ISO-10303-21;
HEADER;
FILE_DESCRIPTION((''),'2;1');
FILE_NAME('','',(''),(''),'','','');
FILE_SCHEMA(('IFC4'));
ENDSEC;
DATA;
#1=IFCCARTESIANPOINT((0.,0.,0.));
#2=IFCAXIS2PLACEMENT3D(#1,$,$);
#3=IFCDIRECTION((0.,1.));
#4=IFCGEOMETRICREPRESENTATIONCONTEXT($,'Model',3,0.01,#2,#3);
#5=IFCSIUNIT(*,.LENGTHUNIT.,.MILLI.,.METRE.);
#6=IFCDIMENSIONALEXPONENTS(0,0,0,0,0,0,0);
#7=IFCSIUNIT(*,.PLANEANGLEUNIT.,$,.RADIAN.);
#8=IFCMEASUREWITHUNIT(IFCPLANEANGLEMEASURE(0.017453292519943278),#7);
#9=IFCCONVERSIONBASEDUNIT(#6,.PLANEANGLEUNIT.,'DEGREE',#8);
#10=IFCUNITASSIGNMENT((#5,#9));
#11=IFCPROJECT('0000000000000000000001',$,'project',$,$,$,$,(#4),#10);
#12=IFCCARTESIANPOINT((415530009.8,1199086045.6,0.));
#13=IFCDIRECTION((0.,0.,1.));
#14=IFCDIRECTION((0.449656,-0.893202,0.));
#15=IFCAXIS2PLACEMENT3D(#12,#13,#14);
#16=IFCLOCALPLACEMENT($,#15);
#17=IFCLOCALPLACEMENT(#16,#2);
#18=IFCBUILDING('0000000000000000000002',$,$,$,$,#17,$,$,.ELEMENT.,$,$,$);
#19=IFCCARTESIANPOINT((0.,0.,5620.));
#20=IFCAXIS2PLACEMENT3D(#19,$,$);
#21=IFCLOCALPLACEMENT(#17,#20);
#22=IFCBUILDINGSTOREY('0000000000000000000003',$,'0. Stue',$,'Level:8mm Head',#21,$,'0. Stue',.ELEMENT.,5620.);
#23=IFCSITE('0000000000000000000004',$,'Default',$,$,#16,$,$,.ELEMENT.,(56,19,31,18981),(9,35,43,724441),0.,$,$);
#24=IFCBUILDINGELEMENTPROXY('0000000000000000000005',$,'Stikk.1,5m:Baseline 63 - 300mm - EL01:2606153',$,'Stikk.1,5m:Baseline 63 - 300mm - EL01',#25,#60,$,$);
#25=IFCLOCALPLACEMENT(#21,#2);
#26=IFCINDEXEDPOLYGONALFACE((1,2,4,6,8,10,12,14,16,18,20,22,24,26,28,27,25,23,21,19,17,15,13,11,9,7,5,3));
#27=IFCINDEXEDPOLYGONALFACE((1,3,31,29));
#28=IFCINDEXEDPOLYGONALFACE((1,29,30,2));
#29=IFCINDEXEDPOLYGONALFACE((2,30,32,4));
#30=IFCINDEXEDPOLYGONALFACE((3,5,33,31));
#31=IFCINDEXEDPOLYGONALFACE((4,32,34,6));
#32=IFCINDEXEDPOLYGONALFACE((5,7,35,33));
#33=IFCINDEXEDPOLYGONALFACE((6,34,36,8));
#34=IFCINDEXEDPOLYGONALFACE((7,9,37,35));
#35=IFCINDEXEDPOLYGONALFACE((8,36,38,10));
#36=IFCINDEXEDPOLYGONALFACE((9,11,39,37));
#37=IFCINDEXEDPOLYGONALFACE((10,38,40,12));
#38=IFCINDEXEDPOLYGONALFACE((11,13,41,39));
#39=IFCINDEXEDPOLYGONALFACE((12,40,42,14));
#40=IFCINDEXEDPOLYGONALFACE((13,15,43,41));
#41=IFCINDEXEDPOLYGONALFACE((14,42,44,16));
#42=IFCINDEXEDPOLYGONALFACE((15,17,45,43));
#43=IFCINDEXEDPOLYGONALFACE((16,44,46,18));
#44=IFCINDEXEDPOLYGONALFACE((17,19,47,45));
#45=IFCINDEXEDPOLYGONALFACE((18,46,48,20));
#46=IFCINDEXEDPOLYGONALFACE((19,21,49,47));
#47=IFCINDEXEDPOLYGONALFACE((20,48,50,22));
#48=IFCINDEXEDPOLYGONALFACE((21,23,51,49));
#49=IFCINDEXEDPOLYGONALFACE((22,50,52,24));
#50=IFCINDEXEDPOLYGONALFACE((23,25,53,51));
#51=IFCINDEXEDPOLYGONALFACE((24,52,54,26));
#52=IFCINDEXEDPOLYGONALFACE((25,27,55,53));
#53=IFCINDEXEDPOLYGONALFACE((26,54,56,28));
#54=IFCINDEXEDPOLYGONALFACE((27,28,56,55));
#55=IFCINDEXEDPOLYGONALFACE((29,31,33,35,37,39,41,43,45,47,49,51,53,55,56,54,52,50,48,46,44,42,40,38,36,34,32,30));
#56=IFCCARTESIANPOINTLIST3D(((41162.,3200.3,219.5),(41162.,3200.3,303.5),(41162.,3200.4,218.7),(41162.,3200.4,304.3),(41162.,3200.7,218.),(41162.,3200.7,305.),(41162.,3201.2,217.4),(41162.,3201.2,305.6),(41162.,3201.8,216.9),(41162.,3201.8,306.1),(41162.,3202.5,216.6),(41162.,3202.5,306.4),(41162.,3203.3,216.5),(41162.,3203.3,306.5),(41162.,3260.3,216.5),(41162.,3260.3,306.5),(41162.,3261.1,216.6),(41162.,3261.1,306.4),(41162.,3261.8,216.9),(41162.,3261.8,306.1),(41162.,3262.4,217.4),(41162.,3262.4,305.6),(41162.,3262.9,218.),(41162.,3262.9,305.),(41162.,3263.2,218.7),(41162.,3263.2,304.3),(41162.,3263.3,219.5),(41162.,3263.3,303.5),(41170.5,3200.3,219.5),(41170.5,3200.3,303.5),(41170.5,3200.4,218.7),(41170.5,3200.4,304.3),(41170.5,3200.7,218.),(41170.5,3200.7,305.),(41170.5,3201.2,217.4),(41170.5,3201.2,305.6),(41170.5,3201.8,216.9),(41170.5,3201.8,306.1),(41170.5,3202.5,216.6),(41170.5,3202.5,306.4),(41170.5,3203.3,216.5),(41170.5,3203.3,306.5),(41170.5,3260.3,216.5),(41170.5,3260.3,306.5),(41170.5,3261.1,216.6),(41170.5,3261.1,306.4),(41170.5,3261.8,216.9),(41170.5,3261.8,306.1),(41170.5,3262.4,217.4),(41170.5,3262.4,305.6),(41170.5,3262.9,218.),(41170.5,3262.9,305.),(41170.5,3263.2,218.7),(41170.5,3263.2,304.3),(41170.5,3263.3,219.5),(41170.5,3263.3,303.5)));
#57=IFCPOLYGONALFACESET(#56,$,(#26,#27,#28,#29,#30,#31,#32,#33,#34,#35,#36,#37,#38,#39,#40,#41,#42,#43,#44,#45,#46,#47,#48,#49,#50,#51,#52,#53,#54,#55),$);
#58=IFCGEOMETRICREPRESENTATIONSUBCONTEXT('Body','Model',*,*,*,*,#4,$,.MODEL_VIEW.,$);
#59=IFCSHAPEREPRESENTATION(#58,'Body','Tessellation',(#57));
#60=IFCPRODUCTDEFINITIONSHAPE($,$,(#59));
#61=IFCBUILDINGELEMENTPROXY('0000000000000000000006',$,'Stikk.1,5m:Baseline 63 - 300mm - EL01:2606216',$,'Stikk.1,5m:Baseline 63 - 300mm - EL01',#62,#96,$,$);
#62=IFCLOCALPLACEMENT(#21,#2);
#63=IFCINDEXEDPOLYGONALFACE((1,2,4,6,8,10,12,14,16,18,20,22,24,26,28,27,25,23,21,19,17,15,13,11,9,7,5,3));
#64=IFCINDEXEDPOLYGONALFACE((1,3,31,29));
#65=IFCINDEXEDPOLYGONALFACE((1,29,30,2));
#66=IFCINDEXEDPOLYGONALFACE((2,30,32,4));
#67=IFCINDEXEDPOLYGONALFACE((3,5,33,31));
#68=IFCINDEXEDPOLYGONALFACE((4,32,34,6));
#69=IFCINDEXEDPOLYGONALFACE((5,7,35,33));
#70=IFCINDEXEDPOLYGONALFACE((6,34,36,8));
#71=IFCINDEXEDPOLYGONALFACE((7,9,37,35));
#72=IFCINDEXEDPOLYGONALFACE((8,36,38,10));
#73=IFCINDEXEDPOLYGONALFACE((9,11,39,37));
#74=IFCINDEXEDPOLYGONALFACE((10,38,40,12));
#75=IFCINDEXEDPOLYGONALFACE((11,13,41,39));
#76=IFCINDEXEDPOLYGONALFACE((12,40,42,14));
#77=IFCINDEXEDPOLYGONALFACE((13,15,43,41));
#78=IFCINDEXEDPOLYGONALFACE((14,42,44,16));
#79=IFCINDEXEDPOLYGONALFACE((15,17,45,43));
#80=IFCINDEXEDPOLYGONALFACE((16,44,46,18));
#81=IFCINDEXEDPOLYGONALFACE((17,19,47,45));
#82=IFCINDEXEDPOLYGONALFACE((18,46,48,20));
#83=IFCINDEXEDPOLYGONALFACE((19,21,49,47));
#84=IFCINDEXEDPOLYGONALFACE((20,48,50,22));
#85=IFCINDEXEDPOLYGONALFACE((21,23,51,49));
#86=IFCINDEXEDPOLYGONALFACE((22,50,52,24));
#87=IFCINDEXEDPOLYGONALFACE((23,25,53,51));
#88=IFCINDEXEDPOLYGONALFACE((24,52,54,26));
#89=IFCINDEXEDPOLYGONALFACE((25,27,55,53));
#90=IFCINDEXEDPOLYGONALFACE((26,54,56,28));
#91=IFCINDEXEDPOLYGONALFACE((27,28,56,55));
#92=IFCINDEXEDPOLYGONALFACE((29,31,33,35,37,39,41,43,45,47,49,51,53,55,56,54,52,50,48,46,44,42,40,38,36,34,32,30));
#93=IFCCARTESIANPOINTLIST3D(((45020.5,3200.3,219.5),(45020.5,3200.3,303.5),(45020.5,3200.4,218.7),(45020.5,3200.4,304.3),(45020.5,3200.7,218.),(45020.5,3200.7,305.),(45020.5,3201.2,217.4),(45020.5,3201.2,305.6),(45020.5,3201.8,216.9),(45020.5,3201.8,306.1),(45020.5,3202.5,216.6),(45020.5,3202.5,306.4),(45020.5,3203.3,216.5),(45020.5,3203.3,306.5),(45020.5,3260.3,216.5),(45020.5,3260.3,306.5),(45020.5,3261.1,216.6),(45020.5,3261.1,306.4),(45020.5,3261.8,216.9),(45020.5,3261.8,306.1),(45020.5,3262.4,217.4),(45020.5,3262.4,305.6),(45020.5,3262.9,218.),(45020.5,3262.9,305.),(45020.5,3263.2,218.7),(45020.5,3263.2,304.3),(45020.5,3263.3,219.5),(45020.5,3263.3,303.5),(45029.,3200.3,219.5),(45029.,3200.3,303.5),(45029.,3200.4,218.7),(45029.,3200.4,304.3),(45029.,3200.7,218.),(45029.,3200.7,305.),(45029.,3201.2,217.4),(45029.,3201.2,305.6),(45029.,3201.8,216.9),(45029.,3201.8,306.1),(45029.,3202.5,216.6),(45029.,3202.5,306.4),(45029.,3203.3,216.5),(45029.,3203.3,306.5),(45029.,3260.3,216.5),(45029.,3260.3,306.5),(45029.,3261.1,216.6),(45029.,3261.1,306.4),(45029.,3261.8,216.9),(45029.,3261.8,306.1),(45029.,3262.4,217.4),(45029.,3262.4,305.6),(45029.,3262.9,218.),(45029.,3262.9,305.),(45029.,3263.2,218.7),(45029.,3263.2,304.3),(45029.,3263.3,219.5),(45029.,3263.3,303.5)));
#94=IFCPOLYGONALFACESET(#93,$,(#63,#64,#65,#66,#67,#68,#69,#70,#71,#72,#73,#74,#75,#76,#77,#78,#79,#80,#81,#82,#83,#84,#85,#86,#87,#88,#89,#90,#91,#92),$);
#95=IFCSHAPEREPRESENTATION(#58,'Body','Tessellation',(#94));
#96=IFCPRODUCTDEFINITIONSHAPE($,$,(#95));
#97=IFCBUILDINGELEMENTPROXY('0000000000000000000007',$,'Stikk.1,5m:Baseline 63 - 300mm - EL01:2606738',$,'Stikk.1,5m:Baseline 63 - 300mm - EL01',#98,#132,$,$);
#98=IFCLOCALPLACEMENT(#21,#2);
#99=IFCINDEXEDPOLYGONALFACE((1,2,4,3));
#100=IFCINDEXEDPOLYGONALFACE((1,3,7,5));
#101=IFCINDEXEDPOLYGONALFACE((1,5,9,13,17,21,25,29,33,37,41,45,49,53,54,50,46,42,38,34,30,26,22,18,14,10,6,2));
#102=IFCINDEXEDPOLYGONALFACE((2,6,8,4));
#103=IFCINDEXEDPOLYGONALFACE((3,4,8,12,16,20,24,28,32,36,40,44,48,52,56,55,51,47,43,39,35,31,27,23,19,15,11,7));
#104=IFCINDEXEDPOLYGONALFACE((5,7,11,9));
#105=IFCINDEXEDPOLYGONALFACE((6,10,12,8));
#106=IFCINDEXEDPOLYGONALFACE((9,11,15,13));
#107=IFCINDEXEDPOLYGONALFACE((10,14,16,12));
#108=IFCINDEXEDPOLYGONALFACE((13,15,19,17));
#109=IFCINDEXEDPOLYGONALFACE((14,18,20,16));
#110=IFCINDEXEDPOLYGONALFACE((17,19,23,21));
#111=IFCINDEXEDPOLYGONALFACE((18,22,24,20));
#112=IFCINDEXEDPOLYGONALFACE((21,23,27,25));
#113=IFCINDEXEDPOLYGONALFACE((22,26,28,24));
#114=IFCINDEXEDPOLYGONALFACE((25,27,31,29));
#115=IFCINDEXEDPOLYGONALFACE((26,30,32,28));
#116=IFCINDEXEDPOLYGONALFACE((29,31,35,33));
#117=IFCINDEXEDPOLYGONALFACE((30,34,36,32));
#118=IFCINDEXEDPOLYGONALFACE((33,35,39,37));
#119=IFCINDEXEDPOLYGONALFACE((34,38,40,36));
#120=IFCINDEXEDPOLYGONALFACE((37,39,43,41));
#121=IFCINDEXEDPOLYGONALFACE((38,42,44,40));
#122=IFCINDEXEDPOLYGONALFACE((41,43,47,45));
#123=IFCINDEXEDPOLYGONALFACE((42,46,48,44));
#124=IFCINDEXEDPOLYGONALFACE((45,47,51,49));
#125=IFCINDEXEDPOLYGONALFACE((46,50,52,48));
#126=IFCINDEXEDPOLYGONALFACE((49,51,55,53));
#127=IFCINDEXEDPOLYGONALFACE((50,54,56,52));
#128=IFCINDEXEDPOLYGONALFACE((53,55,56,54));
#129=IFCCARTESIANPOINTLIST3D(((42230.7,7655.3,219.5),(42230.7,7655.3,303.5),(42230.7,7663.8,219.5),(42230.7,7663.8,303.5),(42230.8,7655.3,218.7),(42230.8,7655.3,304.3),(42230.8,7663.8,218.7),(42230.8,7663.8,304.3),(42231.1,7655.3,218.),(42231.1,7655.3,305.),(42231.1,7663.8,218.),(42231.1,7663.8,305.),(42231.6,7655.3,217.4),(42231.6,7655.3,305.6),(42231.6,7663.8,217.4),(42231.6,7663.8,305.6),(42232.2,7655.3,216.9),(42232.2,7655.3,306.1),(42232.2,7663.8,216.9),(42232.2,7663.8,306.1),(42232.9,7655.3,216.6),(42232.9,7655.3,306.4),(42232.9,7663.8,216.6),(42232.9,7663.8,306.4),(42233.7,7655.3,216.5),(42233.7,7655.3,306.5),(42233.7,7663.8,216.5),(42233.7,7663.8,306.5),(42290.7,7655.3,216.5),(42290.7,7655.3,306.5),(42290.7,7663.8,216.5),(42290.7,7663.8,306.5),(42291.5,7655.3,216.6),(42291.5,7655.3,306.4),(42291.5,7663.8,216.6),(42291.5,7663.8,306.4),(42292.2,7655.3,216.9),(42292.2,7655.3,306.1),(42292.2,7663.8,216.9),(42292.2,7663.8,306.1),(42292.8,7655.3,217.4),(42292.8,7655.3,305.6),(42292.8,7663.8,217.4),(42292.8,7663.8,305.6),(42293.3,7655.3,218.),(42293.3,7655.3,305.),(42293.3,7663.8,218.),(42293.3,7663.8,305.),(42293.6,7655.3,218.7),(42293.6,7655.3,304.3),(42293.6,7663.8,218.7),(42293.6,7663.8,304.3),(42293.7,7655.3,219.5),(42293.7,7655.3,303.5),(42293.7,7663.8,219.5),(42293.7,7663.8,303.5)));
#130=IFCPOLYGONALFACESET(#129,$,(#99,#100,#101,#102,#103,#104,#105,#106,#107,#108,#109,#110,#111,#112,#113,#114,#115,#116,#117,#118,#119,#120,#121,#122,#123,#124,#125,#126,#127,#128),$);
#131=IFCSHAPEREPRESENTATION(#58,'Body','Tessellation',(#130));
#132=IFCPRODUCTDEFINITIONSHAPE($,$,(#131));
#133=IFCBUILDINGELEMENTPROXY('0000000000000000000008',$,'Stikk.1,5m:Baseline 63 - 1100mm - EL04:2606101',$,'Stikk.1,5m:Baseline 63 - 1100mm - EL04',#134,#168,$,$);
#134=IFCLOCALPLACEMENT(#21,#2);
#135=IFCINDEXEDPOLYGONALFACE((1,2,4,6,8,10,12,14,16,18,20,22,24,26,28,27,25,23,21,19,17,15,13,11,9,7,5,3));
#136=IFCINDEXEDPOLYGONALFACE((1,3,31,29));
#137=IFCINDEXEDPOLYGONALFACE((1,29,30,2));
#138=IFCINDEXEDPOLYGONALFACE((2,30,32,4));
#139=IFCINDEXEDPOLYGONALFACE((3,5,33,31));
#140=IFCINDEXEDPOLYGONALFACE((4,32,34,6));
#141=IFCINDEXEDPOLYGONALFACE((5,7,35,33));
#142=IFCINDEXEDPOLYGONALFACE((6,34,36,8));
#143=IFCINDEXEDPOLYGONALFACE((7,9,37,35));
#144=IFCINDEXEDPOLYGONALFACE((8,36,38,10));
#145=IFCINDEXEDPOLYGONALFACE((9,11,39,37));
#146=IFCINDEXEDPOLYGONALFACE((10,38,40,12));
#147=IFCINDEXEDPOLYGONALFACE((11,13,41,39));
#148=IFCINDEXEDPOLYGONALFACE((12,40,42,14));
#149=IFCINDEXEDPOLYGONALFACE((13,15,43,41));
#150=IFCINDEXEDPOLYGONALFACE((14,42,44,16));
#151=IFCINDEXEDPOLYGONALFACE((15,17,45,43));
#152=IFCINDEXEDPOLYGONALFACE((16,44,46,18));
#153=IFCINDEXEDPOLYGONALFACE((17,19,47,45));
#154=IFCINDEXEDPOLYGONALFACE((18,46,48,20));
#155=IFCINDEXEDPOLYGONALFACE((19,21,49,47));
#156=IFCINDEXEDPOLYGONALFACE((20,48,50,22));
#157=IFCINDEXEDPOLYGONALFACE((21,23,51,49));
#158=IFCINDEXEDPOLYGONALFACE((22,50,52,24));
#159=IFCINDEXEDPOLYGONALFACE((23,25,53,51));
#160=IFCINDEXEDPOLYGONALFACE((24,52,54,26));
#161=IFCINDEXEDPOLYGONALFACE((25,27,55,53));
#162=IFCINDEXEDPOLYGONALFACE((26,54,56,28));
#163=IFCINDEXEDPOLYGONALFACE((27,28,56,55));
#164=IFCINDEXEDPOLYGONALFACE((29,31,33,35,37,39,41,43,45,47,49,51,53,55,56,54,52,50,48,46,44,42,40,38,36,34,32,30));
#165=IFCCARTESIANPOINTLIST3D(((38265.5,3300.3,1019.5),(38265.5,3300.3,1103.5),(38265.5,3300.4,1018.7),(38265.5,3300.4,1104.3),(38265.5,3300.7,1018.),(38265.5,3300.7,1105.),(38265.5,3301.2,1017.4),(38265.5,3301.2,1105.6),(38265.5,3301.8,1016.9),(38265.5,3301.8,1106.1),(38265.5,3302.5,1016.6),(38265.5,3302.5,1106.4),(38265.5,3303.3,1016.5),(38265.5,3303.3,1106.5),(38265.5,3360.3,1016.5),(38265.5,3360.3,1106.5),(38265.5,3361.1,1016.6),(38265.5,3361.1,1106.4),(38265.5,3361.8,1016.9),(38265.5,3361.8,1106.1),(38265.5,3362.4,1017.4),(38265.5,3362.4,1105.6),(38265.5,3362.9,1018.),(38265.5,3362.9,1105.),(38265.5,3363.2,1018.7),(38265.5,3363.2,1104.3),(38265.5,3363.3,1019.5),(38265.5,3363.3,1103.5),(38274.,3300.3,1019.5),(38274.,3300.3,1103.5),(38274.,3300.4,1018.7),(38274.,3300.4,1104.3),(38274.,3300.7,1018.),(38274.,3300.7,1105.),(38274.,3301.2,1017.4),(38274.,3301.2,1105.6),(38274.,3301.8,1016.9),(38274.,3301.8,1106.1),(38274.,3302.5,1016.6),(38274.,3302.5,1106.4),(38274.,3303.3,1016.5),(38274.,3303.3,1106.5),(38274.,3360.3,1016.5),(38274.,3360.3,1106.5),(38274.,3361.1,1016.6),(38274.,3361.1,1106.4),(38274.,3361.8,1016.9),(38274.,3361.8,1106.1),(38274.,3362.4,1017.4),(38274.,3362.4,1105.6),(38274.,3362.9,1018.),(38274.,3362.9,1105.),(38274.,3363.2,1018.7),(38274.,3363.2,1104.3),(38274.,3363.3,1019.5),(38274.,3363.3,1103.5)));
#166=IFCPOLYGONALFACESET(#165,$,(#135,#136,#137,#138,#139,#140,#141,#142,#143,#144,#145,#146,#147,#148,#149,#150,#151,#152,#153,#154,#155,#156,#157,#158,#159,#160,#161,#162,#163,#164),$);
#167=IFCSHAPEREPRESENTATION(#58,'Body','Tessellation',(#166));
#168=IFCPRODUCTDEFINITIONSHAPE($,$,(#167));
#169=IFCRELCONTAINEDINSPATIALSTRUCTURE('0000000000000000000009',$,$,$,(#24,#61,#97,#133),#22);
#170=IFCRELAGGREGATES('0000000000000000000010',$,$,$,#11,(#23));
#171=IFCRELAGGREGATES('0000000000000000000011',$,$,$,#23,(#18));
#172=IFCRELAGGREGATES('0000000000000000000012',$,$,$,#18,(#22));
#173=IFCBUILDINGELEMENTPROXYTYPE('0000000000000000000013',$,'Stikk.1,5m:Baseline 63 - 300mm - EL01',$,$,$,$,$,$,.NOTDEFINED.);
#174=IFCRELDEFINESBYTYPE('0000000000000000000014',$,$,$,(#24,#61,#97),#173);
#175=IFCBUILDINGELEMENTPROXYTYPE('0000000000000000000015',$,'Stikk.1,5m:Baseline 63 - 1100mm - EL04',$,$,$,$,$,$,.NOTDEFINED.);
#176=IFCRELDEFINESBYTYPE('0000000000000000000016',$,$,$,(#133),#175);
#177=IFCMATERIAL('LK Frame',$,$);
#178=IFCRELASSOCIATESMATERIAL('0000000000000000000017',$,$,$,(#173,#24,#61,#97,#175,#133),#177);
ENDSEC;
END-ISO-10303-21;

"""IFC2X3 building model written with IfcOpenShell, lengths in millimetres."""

from ifc_helpers import new_model, entity, si_unit, converted_unit, direction, frame, frame_2d, origin, place, context, subcontext, project, spatial, polyline, circle_curve, parameter, trimmed, segment, composite_curve, outline, extrude, source, transform, mapped, material, type_object, type_shapes, element, save


model = new_model("IFC2X3")

# Units and contexts
model_context = context("Model", 3, precision=0.01, world=origin(), true_north=direction((0.0, 1.0)))
body_context = subcontext(model_context, "Body", "Model", "MODEL_VIEW")
ifc_project = project(units=[si_unit("LENGTHUNIT", "METRE", prefix="MILLI"), converted_unit("PLANEANGLEUNIT", "DEGREE", entity("IfcPlaneAngleMeasure", 0.017453292519943278), si_unit("PLANEANGLEUNIT", "RADIAN"), dimensions=[0, 0, 0, 0, 0, 0, 0])], contexts=[model_context])

# Site, building, storey
site_placement = place(None, frame((415530009.8, 1199086045.6, 0.0), z_axis=(0.0, 0.0, 1.0), x_axis=(0.449656, -0.893202, 0.0)))
site = spatial("IfcSite", under=ifc_project, at=site_placement, Name="Default", CompositionType="ELEMENT", RefLatitude=(56, 19, 31, 18981), RefLongitude=(9, 35, 43, 724441), RefElevation=0.0)
building_placement = place(site_placement, origin())
building = spatial("IfcBuilding", under=site, at=building_placement, CompositionType="ELEMENT")
storey_placement = place(building_placement, frame((0.0, 0.0, 5620.0)))
storey = spatial("IfcBuildingStorey", under=building, at=storey_placement, Name="0. Stue", ObjectType="Level:8mm Head", LongName="0. Stue", CompositionType="ELEMENT", Elevation=5620.0)

# Building element proxies
ifc_material_1 = material(Name="LK Frame")
building_element_proxy_type_1 = type_object("IfcBuildingElementProxyType", Name="Stikk.1,5m:Baseline 63 - 300mm - EL01", PredefinedType="NOTDEFINED", material=ifc_material_1)
shared_shape_1 = source(origin(), body_context, "Body", "SweptSolid", [
    extrude(outline(composite_curve([segment(polyline([(-42.0, -31.5), (42.0, -31.5)]), True, "CONTINUOUS"), segment(trimmed(circle_curve(frame_2d((42.0, -28.5), x_axis=(-1.0, 0.0)), 3.0), [parameter(90.0)], [parameter(180.0)], True, "PARAMETER"), True, "CONTINUOUS"), segment(polyline([(45.0, -28.5), (45.0, 28.5)]), True, "CONTINUOUS"), segment(trimmed(circle_curve(frame_2d((42.0, 28.5), x_axis=(-1.0, 0.0)), 3.0), [parameter(180.0)], [parameter(270.0)], True, "PARAMETER"), True, "CONTINUOUS"), segment(polyline([(42.0, 31.5), (-42.0, 31.5)]), True, "CONTINUOUS"), segment(trimmed(circle_curve(frame_2d((-42.0, 28.5), x_axis=(1.0, 0.0)), 3.0), [parameter(90.0)], [parameter(180.0)], True, "PARAMETER"), True, "CONTINUOUS"), segment(polyline([(-45.0, 28.5), (-45.0, -28.5)]), True, "CONTINUOUS"), segment(trimmed(circle_curve(frame_2d((-42.0, -28.5), x_axis=(1.0, 0.0)), 3.0), [parameter(180.0)], [parameter(270.0)], True, "PARAMETER"), True, "CONTINUOUS")], self_intersect=False)), frame((0.0, -38.5, 0.0), z_axis=(0.0, 0.0, 1.0), x_axis=(0.0, 1.0, 0.0)), (0.0, 0.0, 1.0), 8.5),
])
type_shapes(building_element_proxy_type_1, [shared_shape_1])
for number, where, z_axis, x_axis, name in (
    (1, (41170.5, 3231.8, 300.0), (-1.0, 0.0, 0.0), (0.0, -1.0, 0.0), "Stikk.1,5m:Baseline 63 - 300mm - EL01:2606153"),
    (2, (45020.5, 3231.8, 300.0), (1.0, 0.0, 0.0), (0.0, 1.0, 0.0), "Stikk.1,5m:Baseline 63 - 300mm - EL01:2606216"),
    (3, (42262.2, 7663.8, 300.0), (0.0, -1.0, 0.0), (1.0, 0.0, 0.0), "Stikk.1,5m:Baseline 63 - 300mm - EL01:2606738"),
):
    element("IfcBuildingElementProxy", number, at=place(storey_placement, frame(where, z_axis=z_axis, x_axis=x_axis)), inside=storey, type_object=building_element_proxy_type_1, material=ifc_material_1, Name=name, ObjectType="Stikk.1,5m:Baseline 63 - 300mm - EL01", context=body_context, shape_type="MappedRepresentation", body=[
        mapped(shared_shape_1, transform((0.0, 0.0, 0.0), scale=1.0)),
    ])
building_element_proxy_type_2 = type_object("IfcBuildingElementProxyType", Name="Stikk.1,5m:Baseline 63 - 1100mm - EL04", PredefinedType="NOTDEFINED", material=ifc_material_1)
shared_shape_2 = source(origin(), body_context, "Body", "SweptSolid", [
    extrude(outline(composite_curve([segment(polyline([(-42.0, -31.5), (42.0, -31.5)]), True, "CONTINUOUS"), segment(trimmed(circle_curve(frame_2d((42.0, -28.5), x_axis=(-1.0, 0.0)), 3.0), [parameter(90.0)], [parameter(180.0)], True, "PARAMETER"), True, "CONTINUOUS"), segment(polyline([(45.0, -28.5), (45.0, 28.5)]), True, "CONTINUOUS"), segment(trimmed(circle_curve(frame_2d((42.0, 28.5), x_axis=(-1.0, 0.0)), 3.0), [parameter(180.0)], [parameter(270.0)], True, "PARAMETER"), True, "CONTINUOUS"), segment(polyline([(42.0, 31.5), (-42.0, 31.5)]), True, "CONTINUOUS"), segment(trimmed(circle_curve(frame_2d((-42.0, 28.5), x_axis=(1.0, 0.0)), 3.0), [parameter(90.0)], [parameter(180.0)], True, "PARAMETER"), True, "CONTINUOUS"), segment(polyline([(-45.0, 28.5), (-45.0, -28.5)]), True, "CONTINUOUS"), segment(trimmed(circle_curve(frame_2d((-42.0, -28.5), x_axis=(1.0, 0.0)), 3.0), [parameter(180.0)], [parameter(270.0)], True, "PARAMETER"), True, "CONTINUOUS")], self_intersect=False)), frame((0.0, -38.5, 0.0), z_axis=(0.0, 0.0, 1.0), x_axis=(0.0, 1.0, 0.0)), (0.0, 0.0, 1.0), 8.5),
])
type_shapes(building_element_proxy_type_2, [shared_shape_2])
proxy_1_placement = place(storey_placement, frame((38265.5, 3331.8, 1100.0), z_axis=(1.0, 0.0, 0.0), x_axis=(0.0, 1.0, 0.0)))
element("IfcBuildingElementProxy", 4, at=proxy_1_placement, inside=storey, type_object=building_element_proxy_type_2, material=ifc_material_1, Name="Stikk.1,5m:Baseline 63 - 1100mm - EL04:2606101", ObjectType="Stikk.1,5m:Baseline 63 - 1100mm - EL04", context=body_context, shape_type="MappedRepresentation", body=[
    mapped(shared_shape_2, transform((0.0, 0.0, 0.0), scale=1.0)),
])

save(model, "model.ifc")
